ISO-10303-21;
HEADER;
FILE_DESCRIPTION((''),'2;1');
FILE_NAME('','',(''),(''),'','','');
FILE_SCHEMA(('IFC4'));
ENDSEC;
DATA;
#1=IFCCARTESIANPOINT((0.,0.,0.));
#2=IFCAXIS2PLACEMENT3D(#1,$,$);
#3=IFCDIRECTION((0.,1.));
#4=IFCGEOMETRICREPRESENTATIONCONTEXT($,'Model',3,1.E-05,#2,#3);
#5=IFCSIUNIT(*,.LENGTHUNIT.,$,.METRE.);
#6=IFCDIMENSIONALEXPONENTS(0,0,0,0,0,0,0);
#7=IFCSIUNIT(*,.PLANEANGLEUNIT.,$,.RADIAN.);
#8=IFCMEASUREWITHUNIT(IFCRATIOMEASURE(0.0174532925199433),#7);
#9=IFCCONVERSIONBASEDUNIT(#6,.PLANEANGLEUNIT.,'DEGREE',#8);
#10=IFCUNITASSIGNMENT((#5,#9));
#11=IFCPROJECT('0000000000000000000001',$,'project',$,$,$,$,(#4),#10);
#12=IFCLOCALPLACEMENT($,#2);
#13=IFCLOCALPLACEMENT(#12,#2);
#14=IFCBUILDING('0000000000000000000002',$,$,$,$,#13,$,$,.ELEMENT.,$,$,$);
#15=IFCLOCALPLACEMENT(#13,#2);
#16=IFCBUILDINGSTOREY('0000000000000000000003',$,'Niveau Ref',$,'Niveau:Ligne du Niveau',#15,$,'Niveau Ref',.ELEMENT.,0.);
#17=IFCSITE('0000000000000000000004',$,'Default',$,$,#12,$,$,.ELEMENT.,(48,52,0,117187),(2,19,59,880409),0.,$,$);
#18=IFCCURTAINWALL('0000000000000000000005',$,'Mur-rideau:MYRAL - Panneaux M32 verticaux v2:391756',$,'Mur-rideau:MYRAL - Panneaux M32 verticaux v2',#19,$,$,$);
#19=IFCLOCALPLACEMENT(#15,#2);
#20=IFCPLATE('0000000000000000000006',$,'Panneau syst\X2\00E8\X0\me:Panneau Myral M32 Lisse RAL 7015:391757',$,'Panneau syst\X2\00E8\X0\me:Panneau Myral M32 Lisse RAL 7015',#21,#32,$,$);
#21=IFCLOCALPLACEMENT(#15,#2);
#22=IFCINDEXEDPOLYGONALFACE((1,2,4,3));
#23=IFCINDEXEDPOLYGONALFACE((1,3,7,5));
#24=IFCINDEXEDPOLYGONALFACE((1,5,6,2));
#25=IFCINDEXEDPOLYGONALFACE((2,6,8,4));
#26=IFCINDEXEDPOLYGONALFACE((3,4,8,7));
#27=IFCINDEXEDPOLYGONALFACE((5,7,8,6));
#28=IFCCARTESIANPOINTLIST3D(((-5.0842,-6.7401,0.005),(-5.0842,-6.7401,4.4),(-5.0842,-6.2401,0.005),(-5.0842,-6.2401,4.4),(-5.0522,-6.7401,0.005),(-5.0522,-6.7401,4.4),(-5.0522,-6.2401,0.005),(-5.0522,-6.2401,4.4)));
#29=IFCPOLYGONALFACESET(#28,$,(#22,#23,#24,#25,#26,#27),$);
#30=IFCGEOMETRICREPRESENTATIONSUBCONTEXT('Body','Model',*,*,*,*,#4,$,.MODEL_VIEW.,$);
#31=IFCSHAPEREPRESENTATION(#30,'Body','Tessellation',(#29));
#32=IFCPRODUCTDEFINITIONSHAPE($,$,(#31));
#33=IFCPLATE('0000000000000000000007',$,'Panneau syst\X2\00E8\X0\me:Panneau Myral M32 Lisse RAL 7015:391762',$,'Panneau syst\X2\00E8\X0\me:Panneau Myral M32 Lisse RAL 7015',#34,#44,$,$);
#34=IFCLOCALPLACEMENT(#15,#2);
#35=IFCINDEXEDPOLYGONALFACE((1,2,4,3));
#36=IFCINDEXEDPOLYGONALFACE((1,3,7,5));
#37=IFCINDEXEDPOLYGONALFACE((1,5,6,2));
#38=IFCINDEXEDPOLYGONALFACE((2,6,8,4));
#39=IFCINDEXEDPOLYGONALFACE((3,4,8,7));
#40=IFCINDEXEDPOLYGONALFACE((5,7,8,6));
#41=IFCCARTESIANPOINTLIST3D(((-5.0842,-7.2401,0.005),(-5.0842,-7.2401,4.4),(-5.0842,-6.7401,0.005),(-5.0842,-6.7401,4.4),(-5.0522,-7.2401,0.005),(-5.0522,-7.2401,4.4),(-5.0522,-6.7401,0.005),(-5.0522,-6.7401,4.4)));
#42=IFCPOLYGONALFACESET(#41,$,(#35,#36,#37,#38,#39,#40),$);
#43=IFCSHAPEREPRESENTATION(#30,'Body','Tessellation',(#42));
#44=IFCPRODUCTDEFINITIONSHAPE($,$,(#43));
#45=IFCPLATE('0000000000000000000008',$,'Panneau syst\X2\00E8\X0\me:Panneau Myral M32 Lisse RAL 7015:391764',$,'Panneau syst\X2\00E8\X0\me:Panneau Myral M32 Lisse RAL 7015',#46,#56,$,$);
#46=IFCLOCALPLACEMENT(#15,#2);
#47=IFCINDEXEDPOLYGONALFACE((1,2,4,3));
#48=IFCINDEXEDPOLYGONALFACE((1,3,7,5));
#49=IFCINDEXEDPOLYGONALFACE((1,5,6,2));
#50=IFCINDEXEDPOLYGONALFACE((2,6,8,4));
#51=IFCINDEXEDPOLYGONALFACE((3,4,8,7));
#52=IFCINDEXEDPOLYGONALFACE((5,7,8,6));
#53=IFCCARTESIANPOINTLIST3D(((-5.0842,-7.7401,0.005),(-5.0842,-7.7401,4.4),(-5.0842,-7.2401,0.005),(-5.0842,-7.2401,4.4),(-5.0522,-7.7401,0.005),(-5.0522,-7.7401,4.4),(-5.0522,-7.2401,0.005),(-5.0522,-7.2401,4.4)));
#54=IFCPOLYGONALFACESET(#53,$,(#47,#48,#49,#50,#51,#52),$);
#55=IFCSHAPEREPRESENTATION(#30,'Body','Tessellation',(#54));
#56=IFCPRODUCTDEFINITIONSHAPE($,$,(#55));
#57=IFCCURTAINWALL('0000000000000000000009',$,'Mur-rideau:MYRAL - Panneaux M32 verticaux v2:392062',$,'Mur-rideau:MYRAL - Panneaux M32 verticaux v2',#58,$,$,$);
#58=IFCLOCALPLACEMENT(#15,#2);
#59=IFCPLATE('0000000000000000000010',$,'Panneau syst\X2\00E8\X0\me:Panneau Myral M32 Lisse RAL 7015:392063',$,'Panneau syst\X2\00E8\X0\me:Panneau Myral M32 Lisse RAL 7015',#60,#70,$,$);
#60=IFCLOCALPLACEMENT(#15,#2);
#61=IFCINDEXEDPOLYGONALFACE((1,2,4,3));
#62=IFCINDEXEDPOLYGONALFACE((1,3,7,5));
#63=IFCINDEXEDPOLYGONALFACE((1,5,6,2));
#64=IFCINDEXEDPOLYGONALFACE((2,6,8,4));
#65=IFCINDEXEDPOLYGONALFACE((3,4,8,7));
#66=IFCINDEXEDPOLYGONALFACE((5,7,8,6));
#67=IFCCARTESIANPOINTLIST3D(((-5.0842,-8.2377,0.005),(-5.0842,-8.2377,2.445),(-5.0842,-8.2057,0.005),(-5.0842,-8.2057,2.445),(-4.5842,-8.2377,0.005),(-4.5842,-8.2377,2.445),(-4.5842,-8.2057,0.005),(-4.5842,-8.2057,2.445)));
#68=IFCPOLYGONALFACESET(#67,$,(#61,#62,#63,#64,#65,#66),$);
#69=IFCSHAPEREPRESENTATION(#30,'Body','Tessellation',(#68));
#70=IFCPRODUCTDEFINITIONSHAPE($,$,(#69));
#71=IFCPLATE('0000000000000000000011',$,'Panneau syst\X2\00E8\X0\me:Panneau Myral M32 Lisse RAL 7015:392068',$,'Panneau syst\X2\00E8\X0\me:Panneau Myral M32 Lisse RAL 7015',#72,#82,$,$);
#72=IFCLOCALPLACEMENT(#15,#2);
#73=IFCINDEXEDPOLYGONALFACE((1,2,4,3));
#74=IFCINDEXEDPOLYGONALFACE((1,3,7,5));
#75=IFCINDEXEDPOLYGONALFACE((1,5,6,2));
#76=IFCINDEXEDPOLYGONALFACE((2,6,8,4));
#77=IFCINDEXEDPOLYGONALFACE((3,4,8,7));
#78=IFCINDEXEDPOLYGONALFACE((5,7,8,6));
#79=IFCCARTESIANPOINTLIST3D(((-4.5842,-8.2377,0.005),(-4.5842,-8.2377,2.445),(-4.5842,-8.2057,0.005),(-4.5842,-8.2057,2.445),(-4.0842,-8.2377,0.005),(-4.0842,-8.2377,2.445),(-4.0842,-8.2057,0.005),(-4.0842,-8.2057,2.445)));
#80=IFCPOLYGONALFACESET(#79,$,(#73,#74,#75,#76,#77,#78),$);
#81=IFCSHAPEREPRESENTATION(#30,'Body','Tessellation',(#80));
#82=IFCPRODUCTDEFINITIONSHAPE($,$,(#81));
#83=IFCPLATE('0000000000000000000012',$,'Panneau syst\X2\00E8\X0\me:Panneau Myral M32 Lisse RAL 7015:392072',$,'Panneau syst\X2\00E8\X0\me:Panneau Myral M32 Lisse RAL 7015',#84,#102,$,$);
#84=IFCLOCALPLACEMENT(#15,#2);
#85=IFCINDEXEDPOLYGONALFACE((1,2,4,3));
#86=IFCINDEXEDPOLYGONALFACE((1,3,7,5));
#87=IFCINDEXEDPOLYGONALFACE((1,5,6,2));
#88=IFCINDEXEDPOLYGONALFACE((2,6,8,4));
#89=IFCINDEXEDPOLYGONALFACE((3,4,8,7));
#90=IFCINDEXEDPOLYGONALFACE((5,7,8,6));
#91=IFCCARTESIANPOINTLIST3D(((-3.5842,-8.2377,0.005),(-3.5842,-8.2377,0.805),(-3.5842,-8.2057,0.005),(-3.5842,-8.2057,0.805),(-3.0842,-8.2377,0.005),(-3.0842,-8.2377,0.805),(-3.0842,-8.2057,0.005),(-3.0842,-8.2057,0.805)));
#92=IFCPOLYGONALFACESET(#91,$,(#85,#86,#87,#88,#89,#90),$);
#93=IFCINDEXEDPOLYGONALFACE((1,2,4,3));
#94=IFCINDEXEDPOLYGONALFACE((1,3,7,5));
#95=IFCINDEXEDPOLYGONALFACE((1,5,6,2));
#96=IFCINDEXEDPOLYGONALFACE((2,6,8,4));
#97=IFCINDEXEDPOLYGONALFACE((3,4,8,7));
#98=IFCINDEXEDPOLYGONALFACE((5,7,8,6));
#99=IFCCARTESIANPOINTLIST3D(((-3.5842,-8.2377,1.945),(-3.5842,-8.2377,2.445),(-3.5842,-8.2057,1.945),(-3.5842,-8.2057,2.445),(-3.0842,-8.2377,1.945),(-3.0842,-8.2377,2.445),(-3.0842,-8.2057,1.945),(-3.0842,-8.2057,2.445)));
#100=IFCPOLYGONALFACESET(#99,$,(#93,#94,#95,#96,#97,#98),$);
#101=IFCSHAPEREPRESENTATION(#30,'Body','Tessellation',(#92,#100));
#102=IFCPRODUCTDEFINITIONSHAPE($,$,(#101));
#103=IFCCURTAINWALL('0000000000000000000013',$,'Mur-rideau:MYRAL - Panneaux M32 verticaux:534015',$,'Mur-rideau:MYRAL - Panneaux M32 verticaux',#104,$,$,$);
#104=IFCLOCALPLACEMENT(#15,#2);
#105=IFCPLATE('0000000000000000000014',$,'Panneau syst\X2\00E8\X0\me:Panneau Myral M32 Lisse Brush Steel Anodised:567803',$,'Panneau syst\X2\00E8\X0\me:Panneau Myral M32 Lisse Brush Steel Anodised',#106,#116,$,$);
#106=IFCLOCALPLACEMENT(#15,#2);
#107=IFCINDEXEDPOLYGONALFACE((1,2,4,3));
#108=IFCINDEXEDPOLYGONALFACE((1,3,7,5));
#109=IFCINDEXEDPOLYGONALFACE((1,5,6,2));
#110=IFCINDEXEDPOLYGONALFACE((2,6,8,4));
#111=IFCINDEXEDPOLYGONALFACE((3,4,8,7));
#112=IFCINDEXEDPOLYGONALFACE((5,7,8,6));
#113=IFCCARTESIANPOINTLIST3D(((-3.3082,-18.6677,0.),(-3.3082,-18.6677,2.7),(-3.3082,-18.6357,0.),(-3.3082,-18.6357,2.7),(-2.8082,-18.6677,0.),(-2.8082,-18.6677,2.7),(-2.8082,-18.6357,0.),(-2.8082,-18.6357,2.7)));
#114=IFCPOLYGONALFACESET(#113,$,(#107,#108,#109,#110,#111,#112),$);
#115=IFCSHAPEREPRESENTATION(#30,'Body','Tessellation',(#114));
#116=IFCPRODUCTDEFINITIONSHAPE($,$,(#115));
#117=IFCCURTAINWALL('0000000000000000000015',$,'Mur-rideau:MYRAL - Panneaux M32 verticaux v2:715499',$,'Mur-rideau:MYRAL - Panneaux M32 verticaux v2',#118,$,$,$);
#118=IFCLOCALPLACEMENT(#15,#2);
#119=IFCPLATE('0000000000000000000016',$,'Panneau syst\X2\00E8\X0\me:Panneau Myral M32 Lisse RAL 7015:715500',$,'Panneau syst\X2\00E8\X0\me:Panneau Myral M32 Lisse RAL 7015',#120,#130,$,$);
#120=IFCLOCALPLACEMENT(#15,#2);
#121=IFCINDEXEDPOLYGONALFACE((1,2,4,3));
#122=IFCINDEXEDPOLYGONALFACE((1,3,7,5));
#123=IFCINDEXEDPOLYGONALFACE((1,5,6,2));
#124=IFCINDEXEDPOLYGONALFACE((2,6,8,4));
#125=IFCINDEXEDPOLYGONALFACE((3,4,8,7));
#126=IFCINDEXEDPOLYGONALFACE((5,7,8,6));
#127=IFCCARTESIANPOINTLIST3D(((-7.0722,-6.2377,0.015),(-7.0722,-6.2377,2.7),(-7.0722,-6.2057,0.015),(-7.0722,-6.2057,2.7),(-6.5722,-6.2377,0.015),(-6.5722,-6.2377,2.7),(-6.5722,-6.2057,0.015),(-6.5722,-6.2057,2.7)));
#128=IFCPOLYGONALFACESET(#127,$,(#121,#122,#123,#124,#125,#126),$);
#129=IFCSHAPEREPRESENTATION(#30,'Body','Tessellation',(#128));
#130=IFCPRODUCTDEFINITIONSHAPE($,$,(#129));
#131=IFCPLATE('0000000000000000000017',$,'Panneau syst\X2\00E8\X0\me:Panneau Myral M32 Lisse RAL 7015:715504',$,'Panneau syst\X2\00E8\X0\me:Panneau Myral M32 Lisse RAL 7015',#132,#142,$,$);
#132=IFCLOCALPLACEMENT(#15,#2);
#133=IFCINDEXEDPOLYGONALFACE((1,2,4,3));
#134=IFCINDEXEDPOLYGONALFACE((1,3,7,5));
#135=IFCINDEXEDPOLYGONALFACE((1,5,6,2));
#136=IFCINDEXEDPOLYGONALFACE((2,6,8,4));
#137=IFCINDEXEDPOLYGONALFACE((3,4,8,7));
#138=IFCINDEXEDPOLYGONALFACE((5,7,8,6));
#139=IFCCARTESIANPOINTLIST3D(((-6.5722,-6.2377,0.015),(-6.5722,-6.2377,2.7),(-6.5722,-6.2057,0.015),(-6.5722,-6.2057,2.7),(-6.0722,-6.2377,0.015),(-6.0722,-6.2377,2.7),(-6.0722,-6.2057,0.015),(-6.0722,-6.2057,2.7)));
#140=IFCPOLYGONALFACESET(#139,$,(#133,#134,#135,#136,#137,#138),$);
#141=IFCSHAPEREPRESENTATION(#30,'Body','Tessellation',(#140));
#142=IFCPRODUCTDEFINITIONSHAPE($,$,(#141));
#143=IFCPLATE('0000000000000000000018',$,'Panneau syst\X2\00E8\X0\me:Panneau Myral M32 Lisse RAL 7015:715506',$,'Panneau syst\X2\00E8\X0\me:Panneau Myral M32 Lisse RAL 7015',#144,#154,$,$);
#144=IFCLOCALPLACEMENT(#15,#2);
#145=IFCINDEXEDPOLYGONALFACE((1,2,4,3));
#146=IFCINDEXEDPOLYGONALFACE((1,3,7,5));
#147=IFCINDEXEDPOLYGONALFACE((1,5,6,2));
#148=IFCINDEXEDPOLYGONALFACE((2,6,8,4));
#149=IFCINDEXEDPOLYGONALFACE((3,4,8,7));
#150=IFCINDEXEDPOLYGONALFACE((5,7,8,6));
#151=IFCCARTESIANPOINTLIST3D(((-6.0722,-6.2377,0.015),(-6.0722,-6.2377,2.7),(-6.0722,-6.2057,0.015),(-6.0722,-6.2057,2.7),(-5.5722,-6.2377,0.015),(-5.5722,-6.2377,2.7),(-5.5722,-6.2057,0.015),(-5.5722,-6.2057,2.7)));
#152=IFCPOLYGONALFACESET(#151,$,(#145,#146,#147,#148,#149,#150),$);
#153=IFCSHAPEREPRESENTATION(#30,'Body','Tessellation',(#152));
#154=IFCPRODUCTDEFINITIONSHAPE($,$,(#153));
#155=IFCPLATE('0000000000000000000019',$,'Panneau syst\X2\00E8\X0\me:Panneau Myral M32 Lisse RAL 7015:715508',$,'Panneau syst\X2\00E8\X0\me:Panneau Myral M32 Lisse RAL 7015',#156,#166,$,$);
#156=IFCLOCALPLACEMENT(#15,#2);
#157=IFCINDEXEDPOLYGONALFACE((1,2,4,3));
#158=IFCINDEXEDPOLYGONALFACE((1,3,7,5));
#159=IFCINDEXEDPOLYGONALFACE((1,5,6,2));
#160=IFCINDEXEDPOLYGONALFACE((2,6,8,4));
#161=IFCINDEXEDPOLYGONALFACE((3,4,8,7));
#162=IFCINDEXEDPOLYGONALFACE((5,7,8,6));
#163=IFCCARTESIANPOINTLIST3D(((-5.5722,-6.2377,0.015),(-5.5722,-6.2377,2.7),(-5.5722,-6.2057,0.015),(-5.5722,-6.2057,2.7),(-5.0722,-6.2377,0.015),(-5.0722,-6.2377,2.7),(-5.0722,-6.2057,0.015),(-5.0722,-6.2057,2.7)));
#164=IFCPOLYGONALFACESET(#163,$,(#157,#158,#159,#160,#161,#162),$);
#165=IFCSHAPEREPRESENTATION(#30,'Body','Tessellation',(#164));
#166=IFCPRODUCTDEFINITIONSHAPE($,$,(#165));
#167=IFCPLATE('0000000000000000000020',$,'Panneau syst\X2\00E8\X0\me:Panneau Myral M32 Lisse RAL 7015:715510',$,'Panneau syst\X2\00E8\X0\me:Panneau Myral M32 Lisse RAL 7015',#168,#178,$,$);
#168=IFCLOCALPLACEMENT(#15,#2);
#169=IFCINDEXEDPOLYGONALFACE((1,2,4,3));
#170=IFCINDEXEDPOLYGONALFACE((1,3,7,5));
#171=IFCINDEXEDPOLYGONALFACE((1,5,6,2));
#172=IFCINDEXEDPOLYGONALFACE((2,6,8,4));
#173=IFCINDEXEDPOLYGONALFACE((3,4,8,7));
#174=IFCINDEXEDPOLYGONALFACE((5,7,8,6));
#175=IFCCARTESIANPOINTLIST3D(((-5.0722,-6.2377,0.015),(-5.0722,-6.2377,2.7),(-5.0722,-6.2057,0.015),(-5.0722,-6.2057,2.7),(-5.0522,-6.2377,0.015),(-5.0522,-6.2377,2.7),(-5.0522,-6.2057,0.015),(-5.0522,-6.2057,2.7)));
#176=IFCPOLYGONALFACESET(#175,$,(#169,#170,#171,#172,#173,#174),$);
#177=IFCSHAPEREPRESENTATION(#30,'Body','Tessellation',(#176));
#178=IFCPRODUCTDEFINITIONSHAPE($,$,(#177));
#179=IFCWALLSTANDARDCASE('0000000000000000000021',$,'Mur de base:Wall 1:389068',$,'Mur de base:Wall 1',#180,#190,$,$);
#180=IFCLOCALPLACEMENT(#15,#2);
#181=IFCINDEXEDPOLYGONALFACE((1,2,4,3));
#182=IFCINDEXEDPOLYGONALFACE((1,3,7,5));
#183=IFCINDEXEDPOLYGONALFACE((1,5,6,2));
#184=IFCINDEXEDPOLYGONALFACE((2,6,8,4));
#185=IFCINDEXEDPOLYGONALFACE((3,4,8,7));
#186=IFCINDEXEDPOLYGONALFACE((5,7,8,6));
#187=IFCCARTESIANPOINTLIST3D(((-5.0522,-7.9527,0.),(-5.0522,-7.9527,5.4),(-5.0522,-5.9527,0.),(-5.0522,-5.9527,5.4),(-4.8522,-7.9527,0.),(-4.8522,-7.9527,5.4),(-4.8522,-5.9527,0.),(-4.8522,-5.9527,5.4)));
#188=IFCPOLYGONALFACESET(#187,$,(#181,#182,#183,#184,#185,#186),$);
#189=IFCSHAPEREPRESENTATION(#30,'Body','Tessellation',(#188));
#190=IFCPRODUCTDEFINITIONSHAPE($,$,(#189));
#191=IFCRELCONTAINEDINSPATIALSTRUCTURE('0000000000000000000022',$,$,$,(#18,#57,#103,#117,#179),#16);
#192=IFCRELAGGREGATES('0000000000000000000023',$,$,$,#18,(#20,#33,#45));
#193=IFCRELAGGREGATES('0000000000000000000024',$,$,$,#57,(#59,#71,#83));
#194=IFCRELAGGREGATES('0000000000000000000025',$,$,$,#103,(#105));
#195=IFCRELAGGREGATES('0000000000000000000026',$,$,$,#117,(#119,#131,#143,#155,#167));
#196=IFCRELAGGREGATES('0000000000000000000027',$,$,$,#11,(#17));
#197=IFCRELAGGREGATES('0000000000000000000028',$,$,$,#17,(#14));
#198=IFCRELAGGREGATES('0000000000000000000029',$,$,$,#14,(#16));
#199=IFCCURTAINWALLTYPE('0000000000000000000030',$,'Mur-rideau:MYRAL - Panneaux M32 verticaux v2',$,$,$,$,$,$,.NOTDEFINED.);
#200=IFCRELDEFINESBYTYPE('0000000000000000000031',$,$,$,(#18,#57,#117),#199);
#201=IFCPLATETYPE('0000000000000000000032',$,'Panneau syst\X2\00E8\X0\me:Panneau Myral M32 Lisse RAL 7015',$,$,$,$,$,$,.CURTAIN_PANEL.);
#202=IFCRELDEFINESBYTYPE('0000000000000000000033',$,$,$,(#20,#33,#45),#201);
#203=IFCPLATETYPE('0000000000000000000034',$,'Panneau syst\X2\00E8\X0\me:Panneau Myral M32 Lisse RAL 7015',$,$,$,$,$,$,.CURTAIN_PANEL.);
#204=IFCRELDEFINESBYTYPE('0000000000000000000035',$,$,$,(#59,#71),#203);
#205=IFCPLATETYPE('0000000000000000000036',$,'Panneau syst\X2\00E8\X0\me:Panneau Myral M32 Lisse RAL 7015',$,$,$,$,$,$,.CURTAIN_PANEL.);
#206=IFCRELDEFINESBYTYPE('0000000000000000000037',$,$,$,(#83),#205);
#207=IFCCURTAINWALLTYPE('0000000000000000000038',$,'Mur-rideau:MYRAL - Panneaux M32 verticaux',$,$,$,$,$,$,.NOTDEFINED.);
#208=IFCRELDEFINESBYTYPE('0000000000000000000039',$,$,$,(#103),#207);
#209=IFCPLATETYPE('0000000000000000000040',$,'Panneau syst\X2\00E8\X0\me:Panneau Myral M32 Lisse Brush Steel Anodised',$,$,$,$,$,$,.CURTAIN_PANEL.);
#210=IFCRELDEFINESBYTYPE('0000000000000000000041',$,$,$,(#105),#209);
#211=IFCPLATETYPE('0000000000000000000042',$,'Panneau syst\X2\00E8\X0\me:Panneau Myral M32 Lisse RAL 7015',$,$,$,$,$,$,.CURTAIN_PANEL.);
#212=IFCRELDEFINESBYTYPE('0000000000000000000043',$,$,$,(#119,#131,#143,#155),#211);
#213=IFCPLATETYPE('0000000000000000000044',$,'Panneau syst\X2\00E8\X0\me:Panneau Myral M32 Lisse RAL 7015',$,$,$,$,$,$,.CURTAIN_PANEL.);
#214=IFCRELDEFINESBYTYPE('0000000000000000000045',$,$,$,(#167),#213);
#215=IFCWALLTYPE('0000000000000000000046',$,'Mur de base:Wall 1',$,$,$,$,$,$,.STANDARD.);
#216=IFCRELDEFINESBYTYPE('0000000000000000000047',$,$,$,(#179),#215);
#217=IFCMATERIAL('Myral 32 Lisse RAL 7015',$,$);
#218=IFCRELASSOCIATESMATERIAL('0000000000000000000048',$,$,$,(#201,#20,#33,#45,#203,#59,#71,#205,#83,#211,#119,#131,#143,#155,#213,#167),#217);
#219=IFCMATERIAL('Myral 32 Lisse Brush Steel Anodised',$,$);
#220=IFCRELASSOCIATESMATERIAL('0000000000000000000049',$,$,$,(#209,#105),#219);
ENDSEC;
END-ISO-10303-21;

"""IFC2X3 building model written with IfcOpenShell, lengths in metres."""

from ifc_helpers import new_model, entity, si_unit, converted_unit, direction, frame, frame_2d, origin, origin_2d_with_axis, place, context, subcontext, project, spatial, rectangle, extrude, source, transform, mapped, material, type_object, type_shapes, element, aggregate, save


model = new_model("IFC2X3")

# Units and contexts
model_context = context("Model", 3, precision=1e-05, world=origin(), true_north=direction((0.0, 1.0)))
body_context = subcontext(model_context, "Body", "Model", "MODEL_VIEW")
ifc_project = project(units=[si_unit("LENGTHUNIT", "METRE"), converted_unit("PLANEANGLEUNIT", "DEGREE", entity("IfcRatioMeasure", 0.0174532925199433), si_unit("PLANEANGLEUNIT", "RADIAN"), dimensions=[0, 0, 0, 0, 0, 0, 0])], contexts=[model_context])

# Site, building, storey
site_placement = place(None, origin())
site = spatial("IfcSite", under=ifc_project, at=site_placement, Name="Default", CompositionType="ELEMENT", RefLatitude=(48, 52, 0, 117187), RefLongitude=(2, 19, 59, 880409), RefElevation=0.0)
building_placement = place(site_placement, origin())
building = spatial("IfcBuilding", under=site, at=building_placement, CompositionType="ELEMENT")
storey_placement = place(building_placement, origin())
storey = spatial("IfcBuildingStorey", under=building, at=storey_placement, Name="Niveau Ref", ObjectType="Niveau:Ligne du Niveau", LongName="Niveau Ref", CompositionType="ELEMENT", Elevation=0.0)

# Curtain walls, plates
curtain_wall_type_1 = type_object("IfcCurtainWallType", Name="Mur-rideau:MYRAL - Panneaux M32 verticaux v2", PredefinedType="NOTDEFINED")
curtain_wall_1_placement = place(storey_placement, origin())
curtain_wall_1 = element("IfcCurtainWall", 1, at=curtain_wall_1_placement, inside=storey, type_object=curtain_wall_type_1, Name="Mur-rideau:MYRAL - Panneaux M32 verticaux v2:391756", ObjectType="Mur-rideau:MYRAL - Panneaux M32 verticaux v2")
ifc_material_1 = material(Name="Myral 32 Lisse RAL 7015")
plate_type_1 = type_object("IfcPlateType", Name="Panneau système:Panneau Myral M32 Lisse RAL 7015", PredefinedType="CURTAIN_PANEL", material=ifc_material_1)
shared_shape_1 = source(origin(), body_context, "Body", "SweptSolid", [
    extrude(rectangle(XDim=0.032, YDim=0.5, at=origin_2d_with_axis()), frame((0.0, -0.016, 0.0), z_axis=(0.0, 0.0, 1.0), x_axis=(0.0, 1.0, 0.0)), (0.0, 0.0, 1.0), 4.395),
])
type_shapes(plate_type_1, [shared_shape_1])
plate_1_placement = place(curtain_wall_1_placement, frame((-5.0522, -6.4901, 0.005), z_axis=(0.0, 0.0, 1.0), x_axis=(0.0, -1.0, 0.0)))
plate_1 = element("IfcPlate", 2, at=plate_1_placement, type_object=plate_type_1, material=ifc_material_1, Name="Panneau système:Panneau Myral M32 Lisse RAL 7015:391757", ObjectType="Panneau système:Panneau Myral M32 Lisse RAL 7015", context=body_context, shape_type="MappedRepresentation", body=[
    mapped(shared_shape_1, transform((0.0, 0.0, 0.0), scale=1.0)),
])
plate_2_placement = place(curtain_wall_1_placement, frame((-5.0522, -6.9901, 0.005), z_axis=(0.0, 0.0, 1.0), x_axis=(0.0, -1.0, 0.0)))
plate_2 = element("IfcPlate", 3, at=plate_2_placement, type_object=plate_type_1, material=ifc_material_1, Name="Panneau système:Panneau Myral M32 Lisse RAL 7015:391762", ObjectType="Panneau système:Panneau Myral M32 Lisse RAL 7015", context=body_context, shape_type="MappedRepresentation", body=[
    mapped(shared_shape_1, transform((0.0, 0.0, 0.0), scale=1.0)),
])
plate_3_placement = place(curtain_wall_1_placement, frame((-5.0522, -7.4901, 0.005), z_axis=(0.0, 0.0, 1.0), x_axis=(0.0, -1.0, 0.0)))
plate_3 = element("IfcPlate", 4, at=plate_3_placement, type_object=plate_type_1, material=ifc_material_1, Name="Panneau système:Panneau Myral M32 Lisse RAL 7015:391764", ObjectType="Panneau système:Panneau Myral M32 Lisse RAL 7015", context=body_context, shape_type="MappedRepresentation", body=[
    mapped(shared_shape_1, transform((0.0, 0.0, 0.0), scale=1.0)),
])
aggregate(curtain_wall_1, [plate_1, plate_2, plate_3])
curtain_wall_2_placement = place(storey_placement, origin())
curtain_wall_2 = element("IfcCurtainWall", 5, at=curtain_wall_2_placement, inside=storey, type_object=curtain_wall_type_1, Name="Mur-rideau:MYRAL - Panneaux M32 verticaux v2:392062", ObjectType="Mur-rideau:MYRAL - Panneaux M32 verticaux v2")
plate_type_2 = type_object("IfcPlateType", Name="Panneau système:Panneau Myral M32 Lisse RAL 7015", PredefinedType="CURTAIN_PANEL", material=ifc_material_1)
shared_shape_2 = source(origin(), body_context, "Body", "SweptSolid", [
    extrude(rectangle(XDim=0.032, YDim=0.5, at=origin_2d_with_axis()), frame((0.0, -0.016, 0.0), z_axis=(0.0, 0.0, 1.0), x_axis=(0.0, 1.0, 0.0)), (0.0, 0.0, 1.0), 2.44),
])
type_shapes(plate_type_2, [shared_shape_2])
plate_4_placement = place(curtain_wall_2_placement, frame((-4.8342, -8.2057, 0.005)))
plate_4 = element("IfcPlate", 6, at=plate_4_placement, type_object=plate_type_2, material=ifc_material_1, Name="Panneau système:Panneau Myral M32 Lisse RAL 7015:392063", ObjectType="Panneau système:Panneau Myral M32 Lisse RAL 7015", context=body_context, shape_type="MappedRepresentation", body=[
    mapped(shared_shape_2, transform((0.0, 0.0, 0.0), scale=1.0)),
])
plate_5_placement = place(curtain_wall_2_placement, frame((-4.3342, -8.2057, 0.005)))
plate_5 = element("IfcPlate", 7, at=plate_5_placement, type_object=plate_type_2, material=ifc_material_1, Name="Panneau système:Panneau Myral M32 Lisse RAL 7015:392068", ObjectType="Panneau système:Panneau Myral M32 Lisse RAL 7015", context=body_context, shape_type="MappedRepresentation", body=[
    mapped(shared_shape_2, transform((0.0, 0.0, 0.0), scale=1.0)),
])
plate_type_3 = type_object("IfcPlateType", Name="Panneau système:Panneau Myral M32 Lisse RAL 7015", PredefinedType="CURTAIN_PANEL", material=ifc_material_1)
shared_shape_3 = source(origin(), body_context, "Body", "SweptSolid", [
    extrude(rectangle(XDim=0.032, YDim=0.5, at=origin_2d_with_axis()), frame((0.0, -0.016, 0.0), z_axis=(0.0, 0.0, 1.0), x_axis=(0.0, 1.0, 0.0)), (0.0, 0.0, 1.0), 0.8),
    extrude(rectangle(XDim=0.032, YDim=0.5, at=origin_2d_with_axis()), frame((0.0, -0.016, 1.94), z_axis=(0.0, 0.0, 1.0), x_axis=(0.0, 1.0, 0.0)), (0.0, 0.0, 1.0), 0.5),
])
type_shapes(plate_type_3, [shared_shape_3])
plate_6_placement = place(curtain_wall_2_placement, frame((-3.3342, -8.2057, 0.005)))
plate_6 = element("IfcPlate", 8, at=plate_6_placement, type_object=plate_type_3, material=ifc_material_1, Name="Panneau système:Panneau Myral M32 Lisse RAL 7015:392072", ObjectType="Panneau système:Panneau Myral M32 Lisse RAL 7015", context=body_context, shape_type="MappedRepresentation", body=[
    mapped(shared_shape_3, transform((0.0, 0.0, 0.0), scale=1.0)),
])
aggregate(curtain_wall_2, [plate_4, plate_5, plate_6])

# Curtain wall, plate
curtain_wall_type_2 = type_object("IfcCurtainWallType", Name="Mur-rideau:MYRAL - Panneaux M32 verticaux", PredefinedType="NOTDEFINED")
curtain_wall_3_placement = place(storey_placement, origin())
curtain_wall_3 = element("IfcCurtainWall", 9, at=curtain_wall_3_placement, inside=storey, type_object=curtain_wall_type_2, Name="Mur-rideau:MYRAL - Panneaux M32 verticaux:534015", ObjectType="Mur-rideau:MYRAL - Panneaux M32 verticaux")
ifc_material_2 = material(Name="Myral 32 Lisse Brush Steel Anodised")
plate_type_4 = type_object("IfcPlateType", Name="Panneau système:Panneau Myral M32 Lisse Brush Steel Anodised", PredefinedType="CURTAIN_PANEL", material=ifc_material_2)
shared_shape_4 = source(origin(), body_context, "Body", "SweptSolid", [
    extrude(rectangle(XDim=0.032, YDim=0.5, at=origin_2d_with_axis()), frame((0.0, -0.016, 0.0), z_axis=(0.0, 0.0, 1.0), x_axis=(0.0, 1.0, 0.0)), (0.0, 0.0, 1.0), 2.7),
])
type_shapes(plate_type_4, [shared_shape_4])
plate_7_placement = place(curtain_wall_3_placement, frame((-3.0582, -18.6357, 0.0)))
plate_7 = element("IfcPlate", 10, at=plate_7_placement, type_object=plate_type_4, material=ifc_material_2, Name="Panneau système:Panneau Myral M32 Lisse Brush Steel Anodised:567803", ObjectType="Panneau système:Panneau Myral M32 Lisse Brush Steel Anodised", context=body_context, shape_type="MappedRepresentation", body=[
    mapped(shared_shape_4, transform((0.0, 0.0, 0.0), scale=1.0)),
])
aggregate(curtain_wall_3, [plate_7])

# Curtain wall, plates
curtain_wall_4_placement = place(storey_placement, origin())
curtain_wall_4 = element("IfcCurtainWall", 11, at=curtain_wall_4_placement, inside=storey, type_object=curtain_wall_type_1, Name="Mur-rideau:MYRAL - Panneaux M32 verticaux v2:715499", ObjectType="Mur-rideau:MYRAL - Panneaux M32 verticaux v2")
plate_type_5 = type_object("IfcPlateType", Name="Panneau système:Panneau Myral M32 Lisse RAL 7015", PredefinedType="CURTAIN_PANEL", material=ifc_material_1)
shared_shape_5 = source(origin(), body_context, "Body", "SweptSolid", [
    extrude(rectangle(XDim=0.032, YDim=0.5, at=origin_2d_with_axis()), frame((0.0, -0.016, 0.0), z_axis=(0.0, 0.0, 1.0), x_axis=(0.0, 1.0, 0.0)), (0.0, 0.0, 1.0), 2.685),
])
type_shapes(plate_type_5, [shared_shape_5])
plate_8_placement = place(curtain_wall_4_placement, frame((-6.8222, -6.2057, 0.015)))
plate_8 = element("IfcPlate", 12, at=plate_8_placement, type_object=plate_type_5, material=ifc_material_1, Name="Panneau système:Panneau Myral M32 Lisse RAL 7015:715500", ObjectType="Panneau système:Panneau Myral M32 Lisse RAL 7015", context=body_context, shape_type="MappedRepresentation", body=[
    mapped(shared_shape_5, transform((0.0, 0.0, 0.0), scale=1.0)),
])
plate_9_placement = place(curtain_wall_4_placement, frame((-6.3222, -6.2057, 0.015)))
plate_9 = element("IfcPlate", 13, at=plate_9_placement, type_object=plate_type_5, material=ifc_material_1, Name="Panneau système:Panneau Myral M32 Lisse RAL 7015:715504", ObjectType="Panneau système:Panneau Myral M32 Lisse RAL 7015", context=body_context, shape_type="MappedRepresentation", body=[
    mapped(shared_shape_5, transform((0.0, 0.0, 0.0), scale=1.0)),
])
plate_10_placement = place(curtain_wall_4_placement, frame((-5.8222, -6.2057, 0.015)))
plate_10 = element("IfcPlate", 14, at=plate_10_placement, type_object=plate_type_5, material=ifc_material_1, Name="Panneau système:Panneau Myral M32 Lisse RAL 7015:715506", ObjectType="Panneau système:Panneau Myral M32 Lisse RAL 7015", context=body_context, shape_type="MappedRepresentation", body=[
    mapped(shared_shape_5, transform((0.0, 0.0, 0.0), scale=1.0)),
])
plate_11_placement = place(curtain_wall_4_placement, frame((-5.3222, -6.2057, 0.015)))
plate_11 = element("IfcPlate", 15, at=plate_11_placement, type_object=plate_type_5, material=ifc_material_1, Name="Panneau système:Panneau Myral M32 Lisse RAL 7015:715508", ObjectType="Panneau système:Panneau Myral M32 Lisse RAL 7015", context=body_context, shape_type="MappedRepresentation", body=[
    mapped(shared_shape_5, transform((0.0, 0.0, 0.0), scale=1.0)),
])
plate_type_6 = type_object("IfcPlateType", Name="Panneau système:Panneau Myral M32 Lisse RAL 7015", PredefinedType="CURTAIN_PANEL", material=ifc_material_1)
shared_shape_6 = source(origin(), body_context, "Body", "SweptSolid", [
    extrude(rectangle(XDim=0.032, YDim=0.02, at=origin_2d_with_axis()), frame((0.0, -0.016, 0.0), z_axis=(0.0, 0.0, 1.0), x_axis=(0.0, 1.0, 0.0)), (0.0, 0.0, 1.0), 2.685),
])
type_shapes(plate_type_6, [shared_shape_6])
plate_12_placement = place(curtain_wall_4_placement, frame((-5.0622, -6.2057, 0.015)))
plate_12 = element("IfcPlate", 16, at=plate_12_placement, type_object=plate_type_6, material=ifc_material_1, Name="Panneau système:Panneau Myral M32 Lisse RAL 7015:715510", ObjectType="Panneau système:Panneau Myral M32 Lisse RAL 7015", context=body_context, shape_type="MappedRepresentation", body=[
    mapped(shared_shape_6, transform((0.0, 0.0, 0.0), scale=1.0)),
])
aggregate(curtain_wall_4, [plate_8, plate_9, plate_10, plate_11, plate_12])

# Wall
wall_type_1 = type_object("IfcWallType", Name="Mur de base:Wall 1", PredefinedType="STANDARD")
wall_1_placement = place(storey_placement, frame((-4.9522, -7.9527, 0.0), z_axis=(0.0, 0.0, 1.0), x_axis=(0.0, 1.0, 0.0)))
element("IfcWallStandardCase", 17, at=wall_1_placement, inside=storey, type_object=wall_type_1, Name="Mur de base:Wall 1:389068", ObjectType="Mur de base:Wall 1", context=body_context, shape_type="SweptSolid", body=[
    extrude(rectangle(XDim=2.0, YDim=0.2, at=frame_2d((1.0, 0.0), x_axis=(-1.0, 0.0))), origin(), (0.0, 0.0, 1.0), 5.4),
])

save(model, "model.ifc")
